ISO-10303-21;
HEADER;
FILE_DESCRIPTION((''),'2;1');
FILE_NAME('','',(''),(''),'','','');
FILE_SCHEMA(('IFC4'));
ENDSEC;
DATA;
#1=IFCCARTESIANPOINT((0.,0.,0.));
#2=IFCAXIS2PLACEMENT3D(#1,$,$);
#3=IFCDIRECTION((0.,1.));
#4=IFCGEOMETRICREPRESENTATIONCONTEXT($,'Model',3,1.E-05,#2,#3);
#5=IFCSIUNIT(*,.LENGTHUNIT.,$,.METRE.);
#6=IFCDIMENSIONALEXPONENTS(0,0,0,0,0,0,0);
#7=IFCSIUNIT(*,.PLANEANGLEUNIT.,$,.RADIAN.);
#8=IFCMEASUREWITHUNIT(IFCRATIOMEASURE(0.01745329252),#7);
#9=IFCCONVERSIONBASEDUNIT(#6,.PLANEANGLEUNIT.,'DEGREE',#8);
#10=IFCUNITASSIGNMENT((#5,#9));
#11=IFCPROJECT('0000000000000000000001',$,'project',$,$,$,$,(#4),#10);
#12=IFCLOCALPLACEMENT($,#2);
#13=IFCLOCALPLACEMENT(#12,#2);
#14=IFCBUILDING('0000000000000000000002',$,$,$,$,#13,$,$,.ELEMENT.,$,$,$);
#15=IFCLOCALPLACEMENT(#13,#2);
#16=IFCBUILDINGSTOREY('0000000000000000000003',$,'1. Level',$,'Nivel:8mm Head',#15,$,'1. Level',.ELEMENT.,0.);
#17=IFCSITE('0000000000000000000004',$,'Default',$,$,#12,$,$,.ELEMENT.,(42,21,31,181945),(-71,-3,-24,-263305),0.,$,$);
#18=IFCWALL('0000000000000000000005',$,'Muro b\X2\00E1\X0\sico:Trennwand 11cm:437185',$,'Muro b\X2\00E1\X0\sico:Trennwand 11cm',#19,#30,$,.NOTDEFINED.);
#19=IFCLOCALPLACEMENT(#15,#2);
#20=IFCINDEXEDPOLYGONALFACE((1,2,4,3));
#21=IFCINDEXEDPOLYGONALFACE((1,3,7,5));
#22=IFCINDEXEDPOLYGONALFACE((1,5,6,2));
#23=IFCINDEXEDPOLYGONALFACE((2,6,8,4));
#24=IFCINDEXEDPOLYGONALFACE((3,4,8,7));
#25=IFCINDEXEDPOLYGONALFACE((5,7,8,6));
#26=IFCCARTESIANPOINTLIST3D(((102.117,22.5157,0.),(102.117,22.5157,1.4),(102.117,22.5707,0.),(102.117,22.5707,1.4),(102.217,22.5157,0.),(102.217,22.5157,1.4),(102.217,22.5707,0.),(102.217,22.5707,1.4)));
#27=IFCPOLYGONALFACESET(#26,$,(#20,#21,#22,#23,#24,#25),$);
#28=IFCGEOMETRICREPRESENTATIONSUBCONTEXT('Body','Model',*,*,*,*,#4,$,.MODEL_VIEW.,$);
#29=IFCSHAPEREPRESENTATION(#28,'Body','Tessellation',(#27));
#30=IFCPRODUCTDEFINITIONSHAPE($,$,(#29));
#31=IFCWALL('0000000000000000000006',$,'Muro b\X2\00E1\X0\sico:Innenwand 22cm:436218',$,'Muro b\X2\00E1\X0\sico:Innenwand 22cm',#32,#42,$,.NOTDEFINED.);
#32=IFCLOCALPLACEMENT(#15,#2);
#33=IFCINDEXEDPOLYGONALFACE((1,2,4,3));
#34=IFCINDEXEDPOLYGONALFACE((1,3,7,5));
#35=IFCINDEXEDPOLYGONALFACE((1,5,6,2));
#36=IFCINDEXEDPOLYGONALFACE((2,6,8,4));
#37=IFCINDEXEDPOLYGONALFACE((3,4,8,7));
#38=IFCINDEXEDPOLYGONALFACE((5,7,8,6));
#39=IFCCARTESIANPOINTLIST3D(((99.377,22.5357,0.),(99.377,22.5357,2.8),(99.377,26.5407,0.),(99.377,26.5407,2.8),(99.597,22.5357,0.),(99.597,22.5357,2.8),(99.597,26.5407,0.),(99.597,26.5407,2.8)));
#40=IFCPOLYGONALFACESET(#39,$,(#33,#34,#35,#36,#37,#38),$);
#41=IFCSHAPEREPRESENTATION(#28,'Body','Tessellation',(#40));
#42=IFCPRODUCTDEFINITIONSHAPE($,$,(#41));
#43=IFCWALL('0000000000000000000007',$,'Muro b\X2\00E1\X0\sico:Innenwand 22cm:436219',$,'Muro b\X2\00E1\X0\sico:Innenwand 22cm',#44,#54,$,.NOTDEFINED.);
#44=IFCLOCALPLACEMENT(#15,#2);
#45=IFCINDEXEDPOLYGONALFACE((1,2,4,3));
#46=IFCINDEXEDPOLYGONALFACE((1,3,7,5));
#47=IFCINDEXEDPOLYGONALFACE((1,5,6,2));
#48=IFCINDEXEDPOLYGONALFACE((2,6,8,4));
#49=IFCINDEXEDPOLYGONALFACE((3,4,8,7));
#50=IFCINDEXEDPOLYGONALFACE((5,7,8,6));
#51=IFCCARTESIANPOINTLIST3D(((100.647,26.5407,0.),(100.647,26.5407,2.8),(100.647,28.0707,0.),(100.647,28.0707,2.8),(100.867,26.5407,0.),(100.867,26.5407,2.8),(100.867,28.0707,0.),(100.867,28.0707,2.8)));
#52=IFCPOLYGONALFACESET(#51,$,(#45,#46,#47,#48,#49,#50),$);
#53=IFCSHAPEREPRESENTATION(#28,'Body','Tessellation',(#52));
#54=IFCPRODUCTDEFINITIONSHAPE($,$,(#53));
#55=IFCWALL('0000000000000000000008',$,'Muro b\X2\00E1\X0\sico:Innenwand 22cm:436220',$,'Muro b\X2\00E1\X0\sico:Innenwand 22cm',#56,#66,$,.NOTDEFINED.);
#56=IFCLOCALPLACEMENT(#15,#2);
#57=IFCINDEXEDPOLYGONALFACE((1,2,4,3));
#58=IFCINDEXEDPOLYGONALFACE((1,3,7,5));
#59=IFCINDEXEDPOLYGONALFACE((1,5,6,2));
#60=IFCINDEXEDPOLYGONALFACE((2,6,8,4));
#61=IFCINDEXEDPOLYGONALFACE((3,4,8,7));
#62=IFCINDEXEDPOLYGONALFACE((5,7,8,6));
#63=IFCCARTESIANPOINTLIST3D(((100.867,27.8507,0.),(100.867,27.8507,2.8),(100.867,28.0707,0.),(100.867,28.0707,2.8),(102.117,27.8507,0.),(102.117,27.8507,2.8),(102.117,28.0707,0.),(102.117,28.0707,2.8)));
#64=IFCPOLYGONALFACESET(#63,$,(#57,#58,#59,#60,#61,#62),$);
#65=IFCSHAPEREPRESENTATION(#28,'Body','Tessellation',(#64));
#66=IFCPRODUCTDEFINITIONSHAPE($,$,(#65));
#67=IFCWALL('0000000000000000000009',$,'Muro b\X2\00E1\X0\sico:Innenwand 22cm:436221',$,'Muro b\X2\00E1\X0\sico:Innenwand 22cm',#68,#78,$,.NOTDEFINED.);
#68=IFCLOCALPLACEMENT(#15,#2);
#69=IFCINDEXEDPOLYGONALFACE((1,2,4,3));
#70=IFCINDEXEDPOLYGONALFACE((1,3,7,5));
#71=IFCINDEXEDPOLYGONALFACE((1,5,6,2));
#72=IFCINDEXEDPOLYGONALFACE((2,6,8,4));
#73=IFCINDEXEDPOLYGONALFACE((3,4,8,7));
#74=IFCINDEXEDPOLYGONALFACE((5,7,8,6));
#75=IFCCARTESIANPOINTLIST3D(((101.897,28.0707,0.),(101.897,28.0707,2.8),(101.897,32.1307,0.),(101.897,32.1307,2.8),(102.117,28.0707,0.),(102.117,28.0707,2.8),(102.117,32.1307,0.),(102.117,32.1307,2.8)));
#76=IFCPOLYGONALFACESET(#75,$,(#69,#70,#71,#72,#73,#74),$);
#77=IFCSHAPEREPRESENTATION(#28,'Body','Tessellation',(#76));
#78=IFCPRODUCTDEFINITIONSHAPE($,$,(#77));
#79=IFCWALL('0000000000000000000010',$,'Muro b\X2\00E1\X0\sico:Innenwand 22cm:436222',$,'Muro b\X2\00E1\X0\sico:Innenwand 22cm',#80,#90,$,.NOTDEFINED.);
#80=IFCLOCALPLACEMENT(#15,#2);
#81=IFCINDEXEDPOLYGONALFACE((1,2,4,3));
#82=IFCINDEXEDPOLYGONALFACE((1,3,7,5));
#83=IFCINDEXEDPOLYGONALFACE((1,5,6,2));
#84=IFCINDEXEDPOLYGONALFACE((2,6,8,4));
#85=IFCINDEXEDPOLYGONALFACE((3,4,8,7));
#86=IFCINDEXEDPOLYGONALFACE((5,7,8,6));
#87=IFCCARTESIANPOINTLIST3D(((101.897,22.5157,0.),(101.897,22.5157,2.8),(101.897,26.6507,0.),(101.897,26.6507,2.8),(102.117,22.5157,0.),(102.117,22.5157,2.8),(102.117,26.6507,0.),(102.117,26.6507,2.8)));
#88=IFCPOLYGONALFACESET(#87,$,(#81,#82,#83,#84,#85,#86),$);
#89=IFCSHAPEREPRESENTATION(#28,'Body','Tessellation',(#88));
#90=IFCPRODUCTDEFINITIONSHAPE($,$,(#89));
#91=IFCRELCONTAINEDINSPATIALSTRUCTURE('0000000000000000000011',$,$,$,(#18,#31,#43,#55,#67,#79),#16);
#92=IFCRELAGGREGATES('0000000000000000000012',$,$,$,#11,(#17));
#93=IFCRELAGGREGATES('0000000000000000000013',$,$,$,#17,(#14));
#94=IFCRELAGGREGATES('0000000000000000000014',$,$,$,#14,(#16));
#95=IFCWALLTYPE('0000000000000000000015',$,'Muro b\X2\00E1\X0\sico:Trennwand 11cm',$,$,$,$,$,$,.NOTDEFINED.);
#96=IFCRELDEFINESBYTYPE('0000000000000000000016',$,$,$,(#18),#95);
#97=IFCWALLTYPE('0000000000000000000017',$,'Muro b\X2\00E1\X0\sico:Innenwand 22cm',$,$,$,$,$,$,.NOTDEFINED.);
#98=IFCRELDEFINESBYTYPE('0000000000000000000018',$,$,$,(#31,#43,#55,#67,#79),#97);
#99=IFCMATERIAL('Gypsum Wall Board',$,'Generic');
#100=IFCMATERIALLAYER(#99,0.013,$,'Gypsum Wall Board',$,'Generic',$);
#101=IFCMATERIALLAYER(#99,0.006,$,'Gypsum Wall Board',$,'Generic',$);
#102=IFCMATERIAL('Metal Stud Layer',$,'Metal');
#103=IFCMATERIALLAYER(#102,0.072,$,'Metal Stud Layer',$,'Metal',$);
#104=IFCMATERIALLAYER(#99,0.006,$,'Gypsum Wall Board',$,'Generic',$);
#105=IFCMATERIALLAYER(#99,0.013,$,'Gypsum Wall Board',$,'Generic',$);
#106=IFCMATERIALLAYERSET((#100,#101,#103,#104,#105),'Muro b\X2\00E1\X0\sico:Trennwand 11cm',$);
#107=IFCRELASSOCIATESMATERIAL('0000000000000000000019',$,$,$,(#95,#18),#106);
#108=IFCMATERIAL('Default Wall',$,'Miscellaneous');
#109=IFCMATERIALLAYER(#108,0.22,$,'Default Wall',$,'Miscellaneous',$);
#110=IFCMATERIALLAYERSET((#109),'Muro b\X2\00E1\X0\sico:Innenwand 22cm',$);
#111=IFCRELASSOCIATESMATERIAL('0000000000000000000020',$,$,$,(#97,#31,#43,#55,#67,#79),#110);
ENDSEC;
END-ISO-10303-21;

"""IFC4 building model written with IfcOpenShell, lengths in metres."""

from ifc_helpers import new_model, entity, si_unit, converted_unit, direction, frame, frame_2d, origin, origin_2d_with_axis, place, context, subcontext, project, spatial, rectangle, extrude, material, layer, layer_set, layer_usage, type_object, element, save


model = new_model("IFC4")

# Units and contexts
model_context = context("Model", 3, precision=1e-05, world=origin(), true_north=direction((0.0, 1.0)))
body_context = subcontext(model_context, "Body", "Model", "MODEL_VIEW")
ifc_project = project(units=[si_unit("LENGTHUNIT", "METRE"), converted_unit("PLANEANGLEUNIT", "DEGREE", entity("IfcRatioMeasure", 0.01745329252), si_unit("PLANEANGLEUNIT", "RADIAN"), dimensions=[0, 0, 0, 0, 0, 0, 0])], contexts=[model_context])

# Site, building, storey
site_placement = place(None, origin())
site = spatial("IfcSite", under=ifc_project, at=site_placement, Name="Default", CompositionType="ELEMENT", RefLatitude=(42, 21, 31, 181945), RefLongitude=(-71, -3, -24, -263305), RefElevation=0.0)
building_placement = place(site_placement, origin())
building = spatial("IfcBuilding", under=site, at=building_placement, CompositionType="ELEMENT")
storey_placement = place(building_placement, origin())
storey = spatial("IfcBuildingStorey", under=building, at=storey_placement, Name="1. Level", ObjectType="Nivel:8mm Head", LongName="1. Level", CompositionType="ELEMENT", Elevation=0.0)

# Shared definitions
ifc_material_1 = material(Name="Gypsum Wall Board", Category="Generic")
ifc_layer_1 = layer(ifc_material_1, 0.013, Name="Gypsum Wall Board", Category="Generic")
ifc_layer_2 = layer(ifc_material_1, 0.006, Name="Gypsum Wall Board", Category="Generic")
ifc_material_2 = material(Name="Metal Stud Layer", Category="Metal")
ifc_layer_3 = layer(ifc_material_2, 0.072, Name="Metal Stud Layer", Category="Metal")
ifc_layer_4 = layer(ifc_material_1, 0.006, Name="Gypsum Wall Board", Category="Generic")
ifc_layer_5 = layer(ifc_material_1, 0.013, Name="Gypsum Wall Board", Category="Generic")
ifc_layer_set_1 = layer_set([ifc_layer_1, ifc_layer_2, ifc_layer_3, ifc_layer_4, ifc_layer_5], Name="Muro básico:Trennwand 11cm")
wall_type_1 = type_object("IfcWallType", Name="Muro básico:Trennwand 11cm", PredefinedType="NOTDEFINED", material=ifc_layer_set_1)

# Walls
ifc_layer_usage_1 = layer_usage(ifc_layer_set_1, "AXIS2", "NEGATIVE", 0.055)
wall_1_placement = place(storey_placement, frame((102.117, 22.5157, 0.0)))
element("IfcWall", 1, at=wall_1_placement, inside=storey, type_object=wall_type_1, material=ifc_layer_usage_1, Name="Muro básico:Trennwand 11cm:437185", ObjectType="Muro básico:Trennwand 11cm", PredefinedType="NOTDEFINED", context=body_context, shape_type="SweptSolid", body=[
    extrude(rectangle(XDim=0.1, YDim=0.055, at=origin_2d_with_axis()), frame((0.05, 0.0275, 0.0)), (0.0, 0.0, 1.0), 1.4),
])
ifc_material_3 = material(Name="Default Wall", Category="Miscellaneous")
ifc_layer_6 = layer(ifc_material_3, 0.22, Name="Default Wall", Category="Miscellaneous")
ifc_layer_set_2 = layer_set([ifc_layer_6], Name="Muro básico:Innenwand 22cm")
ifc_layer_usage_2 = layer_usage(ifc_layer_set_2, "AXIS2", "NEGATIVE", 0.11)
wall_type_2 = type_object("IfcWallType", Name="Muro básico:Innenwand 22cm", PredefinedType="NOTDEFINED", material=ifc_layer_set_2)
wall_2_placement = place(storey_placement, frame((99.487, 22.5357, 0.0), z_axis=(0.0, 0.0, 1.0), x_axis=(0.0, 1.0, 0.0)))
element("IfcWall", 2, at=wall_2_placement, inside=storey, type_object=wall_type_2, material=ifc_layer_usage_2, Name="Muro básico:Innenwand 22cm:436218", ObjectType="Muro básico:Innenwand 22cm", PredefinedType="NOTDEFINED", context=body_context, shape_type="SweptSolid", body=[
    extrude(rectangle(XDim=4.005, YDim=0.22, at=frame_2d((2.0025, 0.0), x_axis=(-1.0, 0.0))), origin(), (0.0, 0.0, 1.0), 2.8),
])
ifc_layer_usage_3 = layer_usage(ifc_layer_set_2, "AXIS2", "NEGATIVE", 0.11)
wall_3_placement = place(storey_placement, frame((100.757, 26.5407, 0.0), z_axis=(0.0, 0.0, 1.0), x_axis=(0.0, 1.0, 0.0)))
element("IfcWall", 3, at=wall_3_placement, inside=storey, type_object=wall_type_2, material=ifc_layer_usage_3, Name="Muro básico:Innenwand 22cm:436219", ObjectType="Muro básico:Innenwand 22cm", PredefinedType="NOTDEFINED", context=body_context, shape_type="SweptSolid", body=[
    extrude(rectangle(XDim=1.53, YDim=0.22, at=frame_2d((0.765, 0.0), x_axis=(-1.0, 0.0))), origin(), (0.0, 0.0, 1.0), 2.8),
])
ifc_layer_usage_4 = layer_usage(ifc_layer_set_2, "AXIS2", "NEGATIVE", 0.11)
wall_4_placement = place(storey_placement, frame((100.867, 27.9607, 0.0)))
element("IfcWall", 4, at=wall_4_placement, inside=storey, type_object=wall_type_2, material=ifc_layer_usage_4, Name="Muro básico:Innenwand 22cm:436220", ObjectType="Muro básico:Innenwand 22cm", PredefinedType="NOTDEFINED", context=body_context, shape_type="SweptSolid", body=[
    extrude(rectangle(XDim=1.25, YDim=0.22, at=frame_2d((0.625, 0.0), x_axis=(-1.0, 0.0))), origin(), (0.0, 0.0, 1.0), 2.8),
])
ifc_layer_usage_5 = layer_usage(ifc_layer_set_2, "AXIS2", "NEGATIVE", 0.11)
wall_5_placement = place(storey_placement, frame((102.007, 28.0707, 0.0), z_axis=(0.0, 0.0, 1.0), x_axis=(0.0, 1.0, 0.0)))
element("IfcWall", 5, at=wall_5_placement, inside=storey, type_object=wall_type_2, material=ifc_layer_usage_5, Name="Muro básico:Innenwand 22cm:436221", ObjectType="Muro básico:Innenwand 22cm", PredefinedType="NOTDEFINED", context=body_context, shape_type="SweptSolid", body=[
    extrude(rectangle(XDim=4.06, YDim=0.22, at=frame_2d((2.03, 0.0), x_axis=(-1.0, 0.0))), origin(), (0.0, 0.0, 1.0), 2.8),
])
ifc_layer_usage_6 = layer_usage(ifc_layer_set_2, "AXIS2", "NEGATIVE", 0.11)
wall_6_placement = place(storey_placement, frame((102.007, 22.5157, 0.0), z_axis=(0.0, 0.0, 1.0), x_axis=(0.0, 1.0, 0.0)))
element("IfcWall", 6, at=wall_6_placement, inside=storey, type_object=wall_type_2, material=ifc_layer_usage_6, Name="Muro básico:Innenwand 22cm:436222", ObjectType="Muro básico:Innenwand 22cm", PredefinedType="NOTDEFINED", context=body_context, shape_type="SweptSolid", body=[
    extrude(rectangle(XDim=4.135, YDim=0.22, at=frame_2d((2.0675, 0.0), x_axis=(-1.0, 0.0))), origin(), (0.0, 0.0, 1.0), 2.8),
])

save(model, "model.ifc")
